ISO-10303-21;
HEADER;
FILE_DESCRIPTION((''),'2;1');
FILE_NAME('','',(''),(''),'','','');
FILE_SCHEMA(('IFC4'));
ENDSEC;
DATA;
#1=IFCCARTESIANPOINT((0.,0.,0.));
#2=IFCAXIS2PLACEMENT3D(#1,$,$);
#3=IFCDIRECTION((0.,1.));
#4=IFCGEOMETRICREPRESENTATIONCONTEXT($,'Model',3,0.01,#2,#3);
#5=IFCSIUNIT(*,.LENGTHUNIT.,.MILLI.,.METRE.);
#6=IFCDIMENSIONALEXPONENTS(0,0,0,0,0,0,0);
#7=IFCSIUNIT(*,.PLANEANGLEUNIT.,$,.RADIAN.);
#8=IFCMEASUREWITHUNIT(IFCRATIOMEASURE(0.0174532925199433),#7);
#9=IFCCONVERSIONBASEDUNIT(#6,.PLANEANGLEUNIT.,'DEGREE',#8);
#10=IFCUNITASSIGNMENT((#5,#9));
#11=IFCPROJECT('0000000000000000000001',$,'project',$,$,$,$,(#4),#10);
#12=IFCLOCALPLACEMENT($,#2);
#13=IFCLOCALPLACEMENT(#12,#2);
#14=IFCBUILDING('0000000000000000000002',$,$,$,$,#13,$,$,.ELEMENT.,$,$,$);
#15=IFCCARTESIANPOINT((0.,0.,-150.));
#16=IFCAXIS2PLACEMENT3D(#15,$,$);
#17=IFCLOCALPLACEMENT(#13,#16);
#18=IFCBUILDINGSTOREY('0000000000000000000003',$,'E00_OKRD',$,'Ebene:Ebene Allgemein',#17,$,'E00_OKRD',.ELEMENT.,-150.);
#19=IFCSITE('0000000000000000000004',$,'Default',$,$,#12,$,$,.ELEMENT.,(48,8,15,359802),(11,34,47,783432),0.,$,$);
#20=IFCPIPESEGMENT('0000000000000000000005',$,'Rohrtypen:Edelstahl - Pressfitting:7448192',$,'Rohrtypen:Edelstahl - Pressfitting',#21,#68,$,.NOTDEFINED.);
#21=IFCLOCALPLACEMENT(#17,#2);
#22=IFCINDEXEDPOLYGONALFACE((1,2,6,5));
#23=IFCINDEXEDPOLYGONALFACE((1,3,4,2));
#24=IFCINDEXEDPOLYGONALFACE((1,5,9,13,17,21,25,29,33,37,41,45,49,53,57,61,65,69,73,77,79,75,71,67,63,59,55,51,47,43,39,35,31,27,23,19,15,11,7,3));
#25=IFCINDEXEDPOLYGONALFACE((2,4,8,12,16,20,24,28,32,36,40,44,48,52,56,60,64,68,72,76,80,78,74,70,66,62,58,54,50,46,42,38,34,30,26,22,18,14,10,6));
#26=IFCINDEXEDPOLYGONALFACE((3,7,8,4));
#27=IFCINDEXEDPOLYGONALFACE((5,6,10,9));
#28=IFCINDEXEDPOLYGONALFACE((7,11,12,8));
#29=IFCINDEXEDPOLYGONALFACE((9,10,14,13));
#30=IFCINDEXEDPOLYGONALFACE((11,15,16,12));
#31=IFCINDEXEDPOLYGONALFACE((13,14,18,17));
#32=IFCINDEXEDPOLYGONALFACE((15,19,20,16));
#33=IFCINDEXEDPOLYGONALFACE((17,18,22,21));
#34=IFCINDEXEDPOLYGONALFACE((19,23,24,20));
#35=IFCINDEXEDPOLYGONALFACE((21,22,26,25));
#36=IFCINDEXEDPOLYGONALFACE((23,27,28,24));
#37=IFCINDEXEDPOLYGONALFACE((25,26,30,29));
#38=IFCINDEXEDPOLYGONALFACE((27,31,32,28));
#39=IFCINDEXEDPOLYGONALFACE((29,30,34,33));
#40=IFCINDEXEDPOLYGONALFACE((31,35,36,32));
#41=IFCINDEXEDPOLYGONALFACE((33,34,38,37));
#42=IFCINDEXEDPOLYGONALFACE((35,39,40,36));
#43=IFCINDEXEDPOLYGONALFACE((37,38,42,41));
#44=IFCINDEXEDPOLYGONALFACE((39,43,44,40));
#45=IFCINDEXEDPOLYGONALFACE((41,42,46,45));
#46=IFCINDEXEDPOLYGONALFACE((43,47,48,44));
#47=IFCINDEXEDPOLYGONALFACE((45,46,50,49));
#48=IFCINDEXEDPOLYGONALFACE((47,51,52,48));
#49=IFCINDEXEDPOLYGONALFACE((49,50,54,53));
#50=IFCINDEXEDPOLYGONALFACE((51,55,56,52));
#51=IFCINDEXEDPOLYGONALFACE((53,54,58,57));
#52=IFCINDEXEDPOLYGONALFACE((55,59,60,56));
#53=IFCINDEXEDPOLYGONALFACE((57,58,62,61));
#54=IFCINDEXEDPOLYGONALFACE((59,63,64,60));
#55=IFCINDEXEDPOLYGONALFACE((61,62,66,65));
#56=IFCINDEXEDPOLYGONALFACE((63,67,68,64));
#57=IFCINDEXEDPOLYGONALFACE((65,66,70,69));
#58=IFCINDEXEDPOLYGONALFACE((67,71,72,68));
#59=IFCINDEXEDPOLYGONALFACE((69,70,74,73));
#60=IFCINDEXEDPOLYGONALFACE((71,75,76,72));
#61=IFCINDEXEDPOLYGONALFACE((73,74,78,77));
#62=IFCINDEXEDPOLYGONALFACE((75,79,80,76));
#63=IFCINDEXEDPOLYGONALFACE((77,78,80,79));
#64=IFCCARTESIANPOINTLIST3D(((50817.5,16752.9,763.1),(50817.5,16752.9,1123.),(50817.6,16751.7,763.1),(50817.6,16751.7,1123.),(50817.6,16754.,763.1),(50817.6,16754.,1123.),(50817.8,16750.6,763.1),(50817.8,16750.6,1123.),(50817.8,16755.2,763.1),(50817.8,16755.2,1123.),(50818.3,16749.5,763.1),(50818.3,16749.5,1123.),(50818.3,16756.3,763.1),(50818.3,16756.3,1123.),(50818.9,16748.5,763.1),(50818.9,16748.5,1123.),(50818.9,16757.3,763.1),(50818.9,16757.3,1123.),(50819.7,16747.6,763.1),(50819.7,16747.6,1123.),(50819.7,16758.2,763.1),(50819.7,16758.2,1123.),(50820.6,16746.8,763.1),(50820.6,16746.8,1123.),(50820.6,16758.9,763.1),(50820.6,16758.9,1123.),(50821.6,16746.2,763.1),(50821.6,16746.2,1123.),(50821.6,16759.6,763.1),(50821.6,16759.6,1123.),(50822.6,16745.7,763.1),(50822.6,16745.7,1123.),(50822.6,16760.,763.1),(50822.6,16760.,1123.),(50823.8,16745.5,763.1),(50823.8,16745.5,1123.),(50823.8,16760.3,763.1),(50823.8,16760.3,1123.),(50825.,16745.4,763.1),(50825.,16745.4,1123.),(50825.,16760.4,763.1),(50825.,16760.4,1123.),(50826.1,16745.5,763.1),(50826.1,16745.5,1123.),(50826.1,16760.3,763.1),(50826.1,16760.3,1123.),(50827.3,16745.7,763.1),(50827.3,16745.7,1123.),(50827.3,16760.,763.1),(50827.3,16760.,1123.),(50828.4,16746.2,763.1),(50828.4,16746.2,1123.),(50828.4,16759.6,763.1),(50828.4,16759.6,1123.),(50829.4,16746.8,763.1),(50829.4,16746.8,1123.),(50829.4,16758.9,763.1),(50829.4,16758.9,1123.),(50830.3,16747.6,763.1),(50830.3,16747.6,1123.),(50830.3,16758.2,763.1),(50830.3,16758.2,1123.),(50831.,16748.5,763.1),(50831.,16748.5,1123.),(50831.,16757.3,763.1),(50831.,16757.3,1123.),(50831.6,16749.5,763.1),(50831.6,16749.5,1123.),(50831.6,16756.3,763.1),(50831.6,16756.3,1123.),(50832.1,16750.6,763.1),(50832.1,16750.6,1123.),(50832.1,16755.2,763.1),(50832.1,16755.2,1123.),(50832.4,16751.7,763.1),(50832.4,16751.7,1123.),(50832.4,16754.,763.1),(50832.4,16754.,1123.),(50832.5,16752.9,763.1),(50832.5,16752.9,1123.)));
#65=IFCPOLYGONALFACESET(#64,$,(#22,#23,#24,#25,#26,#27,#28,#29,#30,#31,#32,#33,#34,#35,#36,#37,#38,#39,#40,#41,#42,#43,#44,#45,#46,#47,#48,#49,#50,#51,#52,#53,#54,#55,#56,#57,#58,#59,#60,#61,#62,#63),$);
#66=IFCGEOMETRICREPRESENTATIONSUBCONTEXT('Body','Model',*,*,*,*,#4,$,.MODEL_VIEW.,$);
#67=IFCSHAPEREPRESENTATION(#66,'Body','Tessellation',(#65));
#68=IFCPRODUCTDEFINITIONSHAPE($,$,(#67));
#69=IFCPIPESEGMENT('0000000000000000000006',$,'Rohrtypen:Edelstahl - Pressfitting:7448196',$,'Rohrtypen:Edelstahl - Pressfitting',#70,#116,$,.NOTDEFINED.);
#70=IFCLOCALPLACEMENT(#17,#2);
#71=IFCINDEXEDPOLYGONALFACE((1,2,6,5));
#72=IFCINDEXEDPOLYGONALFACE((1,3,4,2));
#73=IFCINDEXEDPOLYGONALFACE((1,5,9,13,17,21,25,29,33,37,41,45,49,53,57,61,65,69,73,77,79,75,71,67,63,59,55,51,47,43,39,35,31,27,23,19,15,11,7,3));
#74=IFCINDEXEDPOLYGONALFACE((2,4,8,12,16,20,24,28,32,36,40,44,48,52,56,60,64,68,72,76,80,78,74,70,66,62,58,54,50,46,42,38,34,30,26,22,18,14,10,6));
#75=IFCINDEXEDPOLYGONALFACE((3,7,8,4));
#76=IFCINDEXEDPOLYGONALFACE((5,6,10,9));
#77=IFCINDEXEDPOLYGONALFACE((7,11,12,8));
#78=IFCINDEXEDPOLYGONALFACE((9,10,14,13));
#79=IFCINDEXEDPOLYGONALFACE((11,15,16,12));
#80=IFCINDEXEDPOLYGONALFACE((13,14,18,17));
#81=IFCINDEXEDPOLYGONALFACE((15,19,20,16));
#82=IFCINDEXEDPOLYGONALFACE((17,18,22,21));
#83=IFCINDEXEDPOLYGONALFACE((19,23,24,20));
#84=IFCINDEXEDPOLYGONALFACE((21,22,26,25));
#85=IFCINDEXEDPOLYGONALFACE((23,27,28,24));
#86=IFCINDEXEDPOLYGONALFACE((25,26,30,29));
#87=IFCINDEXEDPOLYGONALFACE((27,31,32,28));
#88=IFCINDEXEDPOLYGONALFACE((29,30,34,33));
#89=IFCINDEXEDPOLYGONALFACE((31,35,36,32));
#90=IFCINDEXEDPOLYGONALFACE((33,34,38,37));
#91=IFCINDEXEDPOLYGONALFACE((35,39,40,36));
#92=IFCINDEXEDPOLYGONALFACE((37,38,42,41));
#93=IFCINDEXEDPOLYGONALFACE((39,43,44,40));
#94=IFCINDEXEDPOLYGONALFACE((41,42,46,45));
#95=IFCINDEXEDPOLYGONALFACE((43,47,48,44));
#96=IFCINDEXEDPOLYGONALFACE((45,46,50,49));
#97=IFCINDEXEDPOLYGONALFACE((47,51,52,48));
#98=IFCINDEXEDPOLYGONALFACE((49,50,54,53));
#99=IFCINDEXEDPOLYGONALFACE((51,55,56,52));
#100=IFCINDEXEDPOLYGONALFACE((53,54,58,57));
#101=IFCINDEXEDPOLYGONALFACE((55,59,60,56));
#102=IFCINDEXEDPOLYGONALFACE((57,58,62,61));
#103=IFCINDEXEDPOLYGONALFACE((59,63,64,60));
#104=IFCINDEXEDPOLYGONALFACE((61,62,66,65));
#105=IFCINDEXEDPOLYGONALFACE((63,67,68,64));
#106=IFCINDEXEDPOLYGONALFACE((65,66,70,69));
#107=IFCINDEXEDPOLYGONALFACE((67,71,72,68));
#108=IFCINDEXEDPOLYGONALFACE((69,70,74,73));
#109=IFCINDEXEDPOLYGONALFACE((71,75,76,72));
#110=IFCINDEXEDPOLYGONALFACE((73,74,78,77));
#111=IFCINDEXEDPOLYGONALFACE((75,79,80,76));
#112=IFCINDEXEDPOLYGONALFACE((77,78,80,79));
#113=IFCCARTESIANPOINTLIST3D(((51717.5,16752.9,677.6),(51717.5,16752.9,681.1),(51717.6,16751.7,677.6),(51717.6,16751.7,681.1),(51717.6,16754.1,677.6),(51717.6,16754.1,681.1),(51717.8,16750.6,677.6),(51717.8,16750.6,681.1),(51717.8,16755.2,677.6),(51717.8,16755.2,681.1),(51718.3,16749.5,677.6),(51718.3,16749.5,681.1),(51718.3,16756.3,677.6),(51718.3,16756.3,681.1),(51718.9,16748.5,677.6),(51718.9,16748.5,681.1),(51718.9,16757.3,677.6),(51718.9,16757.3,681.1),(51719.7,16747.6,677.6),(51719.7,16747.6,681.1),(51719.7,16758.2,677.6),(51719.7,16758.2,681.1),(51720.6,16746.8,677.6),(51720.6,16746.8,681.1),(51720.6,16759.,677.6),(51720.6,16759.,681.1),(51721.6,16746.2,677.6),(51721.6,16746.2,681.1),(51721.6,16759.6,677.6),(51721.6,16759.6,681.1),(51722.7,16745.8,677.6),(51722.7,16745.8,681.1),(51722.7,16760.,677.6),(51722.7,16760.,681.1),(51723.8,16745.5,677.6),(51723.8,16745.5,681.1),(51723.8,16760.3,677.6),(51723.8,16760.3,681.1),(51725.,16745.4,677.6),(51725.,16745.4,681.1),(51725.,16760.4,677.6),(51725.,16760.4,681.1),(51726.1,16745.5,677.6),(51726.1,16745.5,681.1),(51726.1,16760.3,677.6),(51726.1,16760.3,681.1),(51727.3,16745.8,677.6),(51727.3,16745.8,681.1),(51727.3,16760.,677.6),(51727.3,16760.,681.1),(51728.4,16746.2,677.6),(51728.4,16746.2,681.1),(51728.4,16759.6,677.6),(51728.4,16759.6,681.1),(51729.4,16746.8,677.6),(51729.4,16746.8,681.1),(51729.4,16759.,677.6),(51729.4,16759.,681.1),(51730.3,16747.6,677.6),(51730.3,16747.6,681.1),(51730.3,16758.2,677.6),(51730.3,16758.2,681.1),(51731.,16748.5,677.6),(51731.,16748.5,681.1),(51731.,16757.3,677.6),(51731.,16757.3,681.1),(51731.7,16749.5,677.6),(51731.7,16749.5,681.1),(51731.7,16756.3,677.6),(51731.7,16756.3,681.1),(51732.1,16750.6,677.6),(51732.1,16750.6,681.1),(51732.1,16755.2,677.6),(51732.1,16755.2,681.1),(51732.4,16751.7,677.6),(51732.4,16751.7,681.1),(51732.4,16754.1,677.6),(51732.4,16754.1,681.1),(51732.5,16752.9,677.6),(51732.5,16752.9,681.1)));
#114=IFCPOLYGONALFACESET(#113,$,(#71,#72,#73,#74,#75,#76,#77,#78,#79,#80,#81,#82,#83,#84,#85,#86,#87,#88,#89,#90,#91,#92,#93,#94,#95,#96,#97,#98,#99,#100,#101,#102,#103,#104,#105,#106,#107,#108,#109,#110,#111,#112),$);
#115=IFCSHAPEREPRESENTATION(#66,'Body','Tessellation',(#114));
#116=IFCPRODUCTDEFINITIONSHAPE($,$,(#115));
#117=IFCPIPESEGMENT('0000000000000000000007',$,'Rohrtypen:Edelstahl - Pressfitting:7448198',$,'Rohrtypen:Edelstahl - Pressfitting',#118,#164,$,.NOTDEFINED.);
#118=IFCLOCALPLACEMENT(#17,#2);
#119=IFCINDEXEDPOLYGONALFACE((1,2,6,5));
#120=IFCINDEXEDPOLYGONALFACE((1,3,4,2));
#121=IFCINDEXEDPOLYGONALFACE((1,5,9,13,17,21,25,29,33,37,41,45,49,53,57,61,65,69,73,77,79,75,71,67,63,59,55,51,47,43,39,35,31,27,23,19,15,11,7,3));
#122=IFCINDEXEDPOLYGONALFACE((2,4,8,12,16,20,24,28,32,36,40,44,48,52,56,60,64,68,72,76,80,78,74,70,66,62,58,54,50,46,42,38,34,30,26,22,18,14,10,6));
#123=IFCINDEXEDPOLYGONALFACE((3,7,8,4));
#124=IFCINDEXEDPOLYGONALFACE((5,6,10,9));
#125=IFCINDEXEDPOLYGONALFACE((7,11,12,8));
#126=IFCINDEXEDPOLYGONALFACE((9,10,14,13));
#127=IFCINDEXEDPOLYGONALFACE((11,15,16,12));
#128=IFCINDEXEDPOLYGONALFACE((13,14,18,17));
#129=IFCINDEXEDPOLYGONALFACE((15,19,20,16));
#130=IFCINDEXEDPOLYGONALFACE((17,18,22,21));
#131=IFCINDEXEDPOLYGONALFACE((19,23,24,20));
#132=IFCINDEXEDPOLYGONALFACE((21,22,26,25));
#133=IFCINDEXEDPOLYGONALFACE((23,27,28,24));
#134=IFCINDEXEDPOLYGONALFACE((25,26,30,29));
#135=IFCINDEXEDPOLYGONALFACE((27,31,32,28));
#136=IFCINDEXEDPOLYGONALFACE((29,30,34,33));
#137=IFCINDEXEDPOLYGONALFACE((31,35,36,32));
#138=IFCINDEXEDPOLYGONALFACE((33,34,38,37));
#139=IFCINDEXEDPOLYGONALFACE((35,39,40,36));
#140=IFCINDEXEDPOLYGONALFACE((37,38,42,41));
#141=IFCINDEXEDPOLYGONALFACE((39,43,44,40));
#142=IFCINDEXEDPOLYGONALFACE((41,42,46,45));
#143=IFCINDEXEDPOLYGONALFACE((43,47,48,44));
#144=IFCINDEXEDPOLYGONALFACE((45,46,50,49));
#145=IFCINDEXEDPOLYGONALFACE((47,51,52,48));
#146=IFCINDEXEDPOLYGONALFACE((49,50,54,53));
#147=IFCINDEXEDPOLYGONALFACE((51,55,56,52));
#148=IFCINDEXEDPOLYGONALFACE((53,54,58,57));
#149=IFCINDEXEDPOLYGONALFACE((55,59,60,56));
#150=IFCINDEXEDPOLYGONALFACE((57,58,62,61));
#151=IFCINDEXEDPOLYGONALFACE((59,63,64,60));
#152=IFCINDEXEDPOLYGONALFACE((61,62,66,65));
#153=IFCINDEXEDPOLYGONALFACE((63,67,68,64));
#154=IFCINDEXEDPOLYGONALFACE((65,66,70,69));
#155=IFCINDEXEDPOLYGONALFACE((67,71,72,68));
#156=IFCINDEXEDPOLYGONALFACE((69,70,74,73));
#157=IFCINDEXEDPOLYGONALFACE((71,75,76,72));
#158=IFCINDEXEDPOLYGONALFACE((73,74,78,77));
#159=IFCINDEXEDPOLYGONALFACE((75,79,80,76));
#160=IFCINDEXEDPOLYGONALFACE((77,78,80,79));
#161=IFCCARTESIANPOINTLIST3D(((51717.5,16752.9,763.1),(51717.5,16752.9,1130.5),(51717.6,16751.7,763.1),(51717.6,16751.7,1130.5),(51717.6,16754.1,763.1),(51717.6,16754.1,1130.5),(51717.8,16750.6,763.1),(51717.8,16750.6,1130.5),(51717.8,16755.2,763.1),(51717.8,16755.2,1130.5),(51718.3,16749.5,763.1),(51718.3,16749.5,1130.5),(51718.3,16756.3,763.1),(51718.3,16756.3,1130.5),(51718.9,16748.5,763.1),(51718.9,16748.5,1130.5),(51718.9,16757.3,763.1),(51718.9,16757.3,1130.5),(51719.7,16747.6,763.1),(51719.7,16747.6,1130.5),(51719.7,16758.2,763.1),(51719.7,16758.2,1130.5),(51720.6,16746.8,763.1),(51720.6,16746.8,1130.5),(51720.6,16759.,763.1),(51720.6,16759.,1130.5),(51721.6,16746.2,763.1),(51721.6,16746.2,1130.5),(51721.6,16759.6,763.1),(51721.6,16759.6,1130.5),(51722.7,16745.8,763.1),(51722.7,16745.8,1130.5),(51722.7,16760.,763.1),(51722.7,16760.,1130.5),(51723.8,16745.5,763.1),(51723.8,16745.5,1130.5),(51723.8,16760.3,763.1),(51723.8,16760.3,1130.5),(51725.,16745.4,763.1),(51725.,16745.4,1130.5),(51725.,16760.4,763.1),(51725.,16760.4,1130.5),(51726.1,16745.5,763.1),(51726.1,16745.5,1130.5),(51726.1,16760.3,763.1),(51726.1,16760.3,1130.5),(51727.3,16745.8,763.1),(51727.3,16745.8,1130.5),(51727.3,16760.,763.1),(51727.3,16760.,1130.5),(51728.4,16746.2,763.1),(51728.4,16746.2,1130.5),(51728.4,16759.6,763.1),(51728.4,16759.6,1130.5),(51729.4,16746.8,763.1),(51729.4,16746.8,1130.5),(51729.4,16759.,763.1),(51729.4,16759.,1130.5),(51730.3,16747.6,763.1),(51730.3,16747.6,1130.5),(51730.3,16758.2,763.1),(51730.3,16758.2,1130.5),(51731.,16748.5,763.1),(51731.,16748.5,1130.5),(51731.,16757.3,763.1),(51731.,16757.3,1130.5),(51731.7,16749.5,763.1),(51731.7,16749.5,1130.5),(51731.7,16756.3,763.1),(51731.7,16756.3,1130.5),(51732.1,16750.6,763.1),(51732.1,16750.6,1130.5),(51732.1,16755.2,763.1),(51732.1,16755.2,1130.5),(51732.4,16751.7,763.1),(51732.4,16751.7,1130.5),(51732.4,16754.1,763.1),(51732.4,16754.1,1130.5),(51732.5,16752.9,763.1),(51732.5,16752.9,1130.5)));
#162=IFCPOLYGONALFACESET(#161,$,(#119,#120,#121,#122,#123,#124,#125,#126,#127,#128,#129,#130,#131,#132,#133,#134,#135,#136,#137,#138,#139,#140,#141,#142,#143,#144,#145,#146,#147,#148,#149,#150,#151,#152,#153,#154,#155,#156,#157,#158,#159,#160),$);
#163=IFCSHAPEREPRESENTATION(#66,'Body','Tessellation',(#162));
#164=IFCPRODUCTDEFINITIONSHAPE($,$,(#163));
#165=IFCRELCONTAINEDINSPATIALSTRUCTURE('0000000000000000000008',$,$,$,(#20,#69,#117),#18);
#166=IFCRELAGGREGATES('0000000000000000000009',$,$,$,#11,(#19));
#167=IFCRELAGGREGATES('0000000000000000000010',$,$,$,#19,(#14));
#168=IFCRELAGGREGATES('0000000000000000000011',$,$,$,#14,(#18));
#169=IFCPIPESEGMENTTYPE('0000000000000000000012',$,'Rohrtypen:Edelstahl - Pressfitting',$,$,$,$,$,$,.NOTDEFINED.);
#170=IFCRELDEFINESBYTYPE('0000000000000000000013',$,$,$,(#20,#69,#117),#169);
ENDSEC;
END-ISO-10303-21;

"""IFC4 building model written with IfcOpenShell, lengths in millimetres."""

from ifc_helpers import new_model, entity, si_unit, converted_unit, direction, frame, origin, place, context, subcontext, project, spatial, indexed_curve, outline, extrude, type_object, element, save


model = new_model("IFC4")

# Units and contexts
model_context = context("Model", 3, precision=0.01, world=origin(), true_north=direction((0.0, 1.0)))
body_context = subcontext(model_context, "Body", "Model", "MODEL_VIEW")
ifc_project = project(units=[si_unit("LENGTHUNIT", "METRE", prefix="MILLI"), converted_unit("PLANEANGLEUNIT", "DEGREE", entity("IfcRatioMeasure", 0.0174532925199433), si_unit("PLANEANGLEUNIT", "RADIAN"), dimensions=[0, 0, 0, 0, 0, 0, 0])], contexts=[model_context])

# Site, building, storey
site_placement = place(None, origin())
site = spatial("IfcSite", under=ifc_project, at=site_placement, Name="Default", CompositionType="ELEMENT", RefLatitude=(48, 8, 15, 359802), RefLongitude=(11, 34, 47, 783432), RefElevation=0.0)
building_placement = place(site_placement, origin())
building = spatial("IfcBuilding", under=site, at=building_placement, CompositionType="ELEMENT")
storey_placement = place(building_placement, frame((0.0, 0.0, -150.0)))
storey = spatial("IfcBuildingStorey", under=building, at=storey_placement, Name="E00_OKRD", ObjectType="Ebene:Ebene Allgemein", LongName="E00_OKRD", CompositionType="ELEMENT", Elevation=-150.0)

# Pipe segments
pipe_segment_type_1 = type_object("IfcPipeSegmentType", Name="Rohrtypen:Edelstahl - Pressfitting", PredefinedType="NOTDEFINED")
pipe_segment_1_placement = place(storey_placement, origin())
element("IfcPipeSegment", 1, at=pipe_segment_1_placement, inside=storey, type_object=pipe_segment_type_1, Name="Rohrtypen:Edelstahl - Pressfitting:7448192", ObjectType="Rohrtypen:Edelstahl - Pressfitting", PredefinedType="NOTDEFINED", context=body_context, shape_type="SweptSolid", body=[
    extrude(outline(indexed_curve([(7.5, 0.0), (7.4, 1.2), (7.1, 2.3), (6.7, 3.4), (6.1, 4.4), (5.3, 5.3), (4.4, 6.1), (3.4, 6.7), (2.3, 7.1), (1.2, 7.4), (0.0, 7.5), (-1.2, 7.4), (-2.3, 7.1), (-3.4, 6.7), (-4.4, 6.1), (-5.3, 5.3), (-6.1, 4.4), (-6.7, 3.4), (-7.1, 2.3), (-7.4, 1.2), (-7.5, 0.0), (-7.4, -1.2), (-7.1, -2.3), (-6.7, -3.4), (-6.1, -4.4), (-5.3, -5.3), (-4.4, -6.1), (-3.4, -6.7), (-2.3, -7.1), (-1.2, -7.4), (0.0, -7.5), (1.2, -7.4), (2.3, -7.1), (3.4, -6.7), (4.4, -6.1), (5.3, -5.3), (6.1, -4.4), (6.7, -3.4), (7.1, -2.3), (7.4, -1.2), (7.5, 0.0)], self_intersect=False)), frame((50825.0, 16752.9, 763.1), z_axis=(0.0, 0.0, 1.0), x_axis=(-1.0, 0.0, 0.0)), (0.0, 0.0, 1.0), 359.9),
])
pipe_segment_2_placement = place(storey_placement, origin())
element("IfcPipeSegment", 2, at=pipe_segment_2_placement, inside=storey, type_object=pipe_segment_type_1, Name="Rohrtypen:Edelstahl - Pressfitting:7448196", ObjectType="Rohrtypen:Edelstahl - Pressfitting", PredefinedType="NOTDEFINED", context=body_context, shape_type="SweptSolid", body=[
    extrude(outline(indexed_curve([(7.5, 0.0), (7.4, 1.2), (7.1, 2.3), (6.7, 3.4), (6.1, 4.4), (5.3, 5.3), (4.4, 6.1), (3.4, 6.7), (2.3, 7.1), (1.2, 7.4), (0.0, 7.5), (-1.2, 7.4), (-2.3, 7.1), (-3.4, 6.7), (-4.4, 6.1), (-5.3, 5.3), (-6.1, 4.4), (-6.7, 3.4), (-7.1, 2.3), (-7.4, 1.2), (-7.5, 0.0), (-7.4, -1.2), (-7.1, -2.3), (-6.7, -3.4), (-6.1, -4.4), (-5.3, -5.3), (-4.4, -6.1), (-3.4, -6.7), (-2.3, -7.1), (-1.2, -7.4), (0.0, -7.5), (1.2, -7.4), (2.3, -7.1), (3.4, -6.7), (4.4, -6.1), (5.3, -5.3), (6.1, -4.4), (6.7, -3.4), (7.1, -2.3), (7.4, -1.2), (7.5, 0.0)], self_intersect=False)), frame((51725.0, 16752.9, 677.6), z_axis=(0.0, 0.0, 1.0), x_axis=(-1.0, 0.0, 0.0)), (0.0, 0.0, 1.0), 3.5),
])
pipe_segment_3_placement = place(storey_placement, origin())
element("IfcPipeSegment", 3, at=pipe_segment_3_placement, inside=storey, type_object=pipe_segment_type_1, Name="Rohrtypen:Edelstahl - Pressfitting:7448198", ObjectType="Rohrtypen:Edelstahl - Pressfitting", PredefinedType="NOTDEFINED", context=body_context, shape_type="SweptSolid", body=[
    extrude(outline(indexed_curve([(7.5, 0.0), (7.4, 1.2), (7.1, 2.3), (6.7, 3.4), (6.1, 4.4), (5.3, 5.3), (4.4, 6.1), (3.4, 6.7), (2.3, 7.1), (1.2, 7.4), (0.0, 7.5), (-1.2, 7.4), (-2.3, 7.1), (-3.4, 6.7), (-4.4, 6.1), (-5.3, 5.3), (-6.1, 4.4), (-6.7, 3.4), (-7.1, 2.3), (-7.4, 1.2), (-7.5, 0.0), (-7.4, -1.2), (-7.1, -2.3), (-6.7, -3.4), (-6.1, -4.4), (-5.3, -5.3), (-4.4, -6.1), (-3.4, -6.7), (-2.3, -7.1), (-1.2, -7.4), (0.0, -7.5), (1.2, -7.4), (2.3, -7.1), (3.4, -6.7), (4.4, -6.1), (5.3, -5.3), (6.1, -4.4), (6.7, -3.4), (7.1, -2.3), (7.4, -1.2), (7.5, 0.0)], self_intersect=False)), frame((51725.0, 16752.9, 763.1), z_axis=(0.0, 0.0, 1.0), x_axis=(-1.0, 0.0, 0.0)), (0.0, 0.0, 1.0), 367.4),
])

save(model, "model.ifc")
